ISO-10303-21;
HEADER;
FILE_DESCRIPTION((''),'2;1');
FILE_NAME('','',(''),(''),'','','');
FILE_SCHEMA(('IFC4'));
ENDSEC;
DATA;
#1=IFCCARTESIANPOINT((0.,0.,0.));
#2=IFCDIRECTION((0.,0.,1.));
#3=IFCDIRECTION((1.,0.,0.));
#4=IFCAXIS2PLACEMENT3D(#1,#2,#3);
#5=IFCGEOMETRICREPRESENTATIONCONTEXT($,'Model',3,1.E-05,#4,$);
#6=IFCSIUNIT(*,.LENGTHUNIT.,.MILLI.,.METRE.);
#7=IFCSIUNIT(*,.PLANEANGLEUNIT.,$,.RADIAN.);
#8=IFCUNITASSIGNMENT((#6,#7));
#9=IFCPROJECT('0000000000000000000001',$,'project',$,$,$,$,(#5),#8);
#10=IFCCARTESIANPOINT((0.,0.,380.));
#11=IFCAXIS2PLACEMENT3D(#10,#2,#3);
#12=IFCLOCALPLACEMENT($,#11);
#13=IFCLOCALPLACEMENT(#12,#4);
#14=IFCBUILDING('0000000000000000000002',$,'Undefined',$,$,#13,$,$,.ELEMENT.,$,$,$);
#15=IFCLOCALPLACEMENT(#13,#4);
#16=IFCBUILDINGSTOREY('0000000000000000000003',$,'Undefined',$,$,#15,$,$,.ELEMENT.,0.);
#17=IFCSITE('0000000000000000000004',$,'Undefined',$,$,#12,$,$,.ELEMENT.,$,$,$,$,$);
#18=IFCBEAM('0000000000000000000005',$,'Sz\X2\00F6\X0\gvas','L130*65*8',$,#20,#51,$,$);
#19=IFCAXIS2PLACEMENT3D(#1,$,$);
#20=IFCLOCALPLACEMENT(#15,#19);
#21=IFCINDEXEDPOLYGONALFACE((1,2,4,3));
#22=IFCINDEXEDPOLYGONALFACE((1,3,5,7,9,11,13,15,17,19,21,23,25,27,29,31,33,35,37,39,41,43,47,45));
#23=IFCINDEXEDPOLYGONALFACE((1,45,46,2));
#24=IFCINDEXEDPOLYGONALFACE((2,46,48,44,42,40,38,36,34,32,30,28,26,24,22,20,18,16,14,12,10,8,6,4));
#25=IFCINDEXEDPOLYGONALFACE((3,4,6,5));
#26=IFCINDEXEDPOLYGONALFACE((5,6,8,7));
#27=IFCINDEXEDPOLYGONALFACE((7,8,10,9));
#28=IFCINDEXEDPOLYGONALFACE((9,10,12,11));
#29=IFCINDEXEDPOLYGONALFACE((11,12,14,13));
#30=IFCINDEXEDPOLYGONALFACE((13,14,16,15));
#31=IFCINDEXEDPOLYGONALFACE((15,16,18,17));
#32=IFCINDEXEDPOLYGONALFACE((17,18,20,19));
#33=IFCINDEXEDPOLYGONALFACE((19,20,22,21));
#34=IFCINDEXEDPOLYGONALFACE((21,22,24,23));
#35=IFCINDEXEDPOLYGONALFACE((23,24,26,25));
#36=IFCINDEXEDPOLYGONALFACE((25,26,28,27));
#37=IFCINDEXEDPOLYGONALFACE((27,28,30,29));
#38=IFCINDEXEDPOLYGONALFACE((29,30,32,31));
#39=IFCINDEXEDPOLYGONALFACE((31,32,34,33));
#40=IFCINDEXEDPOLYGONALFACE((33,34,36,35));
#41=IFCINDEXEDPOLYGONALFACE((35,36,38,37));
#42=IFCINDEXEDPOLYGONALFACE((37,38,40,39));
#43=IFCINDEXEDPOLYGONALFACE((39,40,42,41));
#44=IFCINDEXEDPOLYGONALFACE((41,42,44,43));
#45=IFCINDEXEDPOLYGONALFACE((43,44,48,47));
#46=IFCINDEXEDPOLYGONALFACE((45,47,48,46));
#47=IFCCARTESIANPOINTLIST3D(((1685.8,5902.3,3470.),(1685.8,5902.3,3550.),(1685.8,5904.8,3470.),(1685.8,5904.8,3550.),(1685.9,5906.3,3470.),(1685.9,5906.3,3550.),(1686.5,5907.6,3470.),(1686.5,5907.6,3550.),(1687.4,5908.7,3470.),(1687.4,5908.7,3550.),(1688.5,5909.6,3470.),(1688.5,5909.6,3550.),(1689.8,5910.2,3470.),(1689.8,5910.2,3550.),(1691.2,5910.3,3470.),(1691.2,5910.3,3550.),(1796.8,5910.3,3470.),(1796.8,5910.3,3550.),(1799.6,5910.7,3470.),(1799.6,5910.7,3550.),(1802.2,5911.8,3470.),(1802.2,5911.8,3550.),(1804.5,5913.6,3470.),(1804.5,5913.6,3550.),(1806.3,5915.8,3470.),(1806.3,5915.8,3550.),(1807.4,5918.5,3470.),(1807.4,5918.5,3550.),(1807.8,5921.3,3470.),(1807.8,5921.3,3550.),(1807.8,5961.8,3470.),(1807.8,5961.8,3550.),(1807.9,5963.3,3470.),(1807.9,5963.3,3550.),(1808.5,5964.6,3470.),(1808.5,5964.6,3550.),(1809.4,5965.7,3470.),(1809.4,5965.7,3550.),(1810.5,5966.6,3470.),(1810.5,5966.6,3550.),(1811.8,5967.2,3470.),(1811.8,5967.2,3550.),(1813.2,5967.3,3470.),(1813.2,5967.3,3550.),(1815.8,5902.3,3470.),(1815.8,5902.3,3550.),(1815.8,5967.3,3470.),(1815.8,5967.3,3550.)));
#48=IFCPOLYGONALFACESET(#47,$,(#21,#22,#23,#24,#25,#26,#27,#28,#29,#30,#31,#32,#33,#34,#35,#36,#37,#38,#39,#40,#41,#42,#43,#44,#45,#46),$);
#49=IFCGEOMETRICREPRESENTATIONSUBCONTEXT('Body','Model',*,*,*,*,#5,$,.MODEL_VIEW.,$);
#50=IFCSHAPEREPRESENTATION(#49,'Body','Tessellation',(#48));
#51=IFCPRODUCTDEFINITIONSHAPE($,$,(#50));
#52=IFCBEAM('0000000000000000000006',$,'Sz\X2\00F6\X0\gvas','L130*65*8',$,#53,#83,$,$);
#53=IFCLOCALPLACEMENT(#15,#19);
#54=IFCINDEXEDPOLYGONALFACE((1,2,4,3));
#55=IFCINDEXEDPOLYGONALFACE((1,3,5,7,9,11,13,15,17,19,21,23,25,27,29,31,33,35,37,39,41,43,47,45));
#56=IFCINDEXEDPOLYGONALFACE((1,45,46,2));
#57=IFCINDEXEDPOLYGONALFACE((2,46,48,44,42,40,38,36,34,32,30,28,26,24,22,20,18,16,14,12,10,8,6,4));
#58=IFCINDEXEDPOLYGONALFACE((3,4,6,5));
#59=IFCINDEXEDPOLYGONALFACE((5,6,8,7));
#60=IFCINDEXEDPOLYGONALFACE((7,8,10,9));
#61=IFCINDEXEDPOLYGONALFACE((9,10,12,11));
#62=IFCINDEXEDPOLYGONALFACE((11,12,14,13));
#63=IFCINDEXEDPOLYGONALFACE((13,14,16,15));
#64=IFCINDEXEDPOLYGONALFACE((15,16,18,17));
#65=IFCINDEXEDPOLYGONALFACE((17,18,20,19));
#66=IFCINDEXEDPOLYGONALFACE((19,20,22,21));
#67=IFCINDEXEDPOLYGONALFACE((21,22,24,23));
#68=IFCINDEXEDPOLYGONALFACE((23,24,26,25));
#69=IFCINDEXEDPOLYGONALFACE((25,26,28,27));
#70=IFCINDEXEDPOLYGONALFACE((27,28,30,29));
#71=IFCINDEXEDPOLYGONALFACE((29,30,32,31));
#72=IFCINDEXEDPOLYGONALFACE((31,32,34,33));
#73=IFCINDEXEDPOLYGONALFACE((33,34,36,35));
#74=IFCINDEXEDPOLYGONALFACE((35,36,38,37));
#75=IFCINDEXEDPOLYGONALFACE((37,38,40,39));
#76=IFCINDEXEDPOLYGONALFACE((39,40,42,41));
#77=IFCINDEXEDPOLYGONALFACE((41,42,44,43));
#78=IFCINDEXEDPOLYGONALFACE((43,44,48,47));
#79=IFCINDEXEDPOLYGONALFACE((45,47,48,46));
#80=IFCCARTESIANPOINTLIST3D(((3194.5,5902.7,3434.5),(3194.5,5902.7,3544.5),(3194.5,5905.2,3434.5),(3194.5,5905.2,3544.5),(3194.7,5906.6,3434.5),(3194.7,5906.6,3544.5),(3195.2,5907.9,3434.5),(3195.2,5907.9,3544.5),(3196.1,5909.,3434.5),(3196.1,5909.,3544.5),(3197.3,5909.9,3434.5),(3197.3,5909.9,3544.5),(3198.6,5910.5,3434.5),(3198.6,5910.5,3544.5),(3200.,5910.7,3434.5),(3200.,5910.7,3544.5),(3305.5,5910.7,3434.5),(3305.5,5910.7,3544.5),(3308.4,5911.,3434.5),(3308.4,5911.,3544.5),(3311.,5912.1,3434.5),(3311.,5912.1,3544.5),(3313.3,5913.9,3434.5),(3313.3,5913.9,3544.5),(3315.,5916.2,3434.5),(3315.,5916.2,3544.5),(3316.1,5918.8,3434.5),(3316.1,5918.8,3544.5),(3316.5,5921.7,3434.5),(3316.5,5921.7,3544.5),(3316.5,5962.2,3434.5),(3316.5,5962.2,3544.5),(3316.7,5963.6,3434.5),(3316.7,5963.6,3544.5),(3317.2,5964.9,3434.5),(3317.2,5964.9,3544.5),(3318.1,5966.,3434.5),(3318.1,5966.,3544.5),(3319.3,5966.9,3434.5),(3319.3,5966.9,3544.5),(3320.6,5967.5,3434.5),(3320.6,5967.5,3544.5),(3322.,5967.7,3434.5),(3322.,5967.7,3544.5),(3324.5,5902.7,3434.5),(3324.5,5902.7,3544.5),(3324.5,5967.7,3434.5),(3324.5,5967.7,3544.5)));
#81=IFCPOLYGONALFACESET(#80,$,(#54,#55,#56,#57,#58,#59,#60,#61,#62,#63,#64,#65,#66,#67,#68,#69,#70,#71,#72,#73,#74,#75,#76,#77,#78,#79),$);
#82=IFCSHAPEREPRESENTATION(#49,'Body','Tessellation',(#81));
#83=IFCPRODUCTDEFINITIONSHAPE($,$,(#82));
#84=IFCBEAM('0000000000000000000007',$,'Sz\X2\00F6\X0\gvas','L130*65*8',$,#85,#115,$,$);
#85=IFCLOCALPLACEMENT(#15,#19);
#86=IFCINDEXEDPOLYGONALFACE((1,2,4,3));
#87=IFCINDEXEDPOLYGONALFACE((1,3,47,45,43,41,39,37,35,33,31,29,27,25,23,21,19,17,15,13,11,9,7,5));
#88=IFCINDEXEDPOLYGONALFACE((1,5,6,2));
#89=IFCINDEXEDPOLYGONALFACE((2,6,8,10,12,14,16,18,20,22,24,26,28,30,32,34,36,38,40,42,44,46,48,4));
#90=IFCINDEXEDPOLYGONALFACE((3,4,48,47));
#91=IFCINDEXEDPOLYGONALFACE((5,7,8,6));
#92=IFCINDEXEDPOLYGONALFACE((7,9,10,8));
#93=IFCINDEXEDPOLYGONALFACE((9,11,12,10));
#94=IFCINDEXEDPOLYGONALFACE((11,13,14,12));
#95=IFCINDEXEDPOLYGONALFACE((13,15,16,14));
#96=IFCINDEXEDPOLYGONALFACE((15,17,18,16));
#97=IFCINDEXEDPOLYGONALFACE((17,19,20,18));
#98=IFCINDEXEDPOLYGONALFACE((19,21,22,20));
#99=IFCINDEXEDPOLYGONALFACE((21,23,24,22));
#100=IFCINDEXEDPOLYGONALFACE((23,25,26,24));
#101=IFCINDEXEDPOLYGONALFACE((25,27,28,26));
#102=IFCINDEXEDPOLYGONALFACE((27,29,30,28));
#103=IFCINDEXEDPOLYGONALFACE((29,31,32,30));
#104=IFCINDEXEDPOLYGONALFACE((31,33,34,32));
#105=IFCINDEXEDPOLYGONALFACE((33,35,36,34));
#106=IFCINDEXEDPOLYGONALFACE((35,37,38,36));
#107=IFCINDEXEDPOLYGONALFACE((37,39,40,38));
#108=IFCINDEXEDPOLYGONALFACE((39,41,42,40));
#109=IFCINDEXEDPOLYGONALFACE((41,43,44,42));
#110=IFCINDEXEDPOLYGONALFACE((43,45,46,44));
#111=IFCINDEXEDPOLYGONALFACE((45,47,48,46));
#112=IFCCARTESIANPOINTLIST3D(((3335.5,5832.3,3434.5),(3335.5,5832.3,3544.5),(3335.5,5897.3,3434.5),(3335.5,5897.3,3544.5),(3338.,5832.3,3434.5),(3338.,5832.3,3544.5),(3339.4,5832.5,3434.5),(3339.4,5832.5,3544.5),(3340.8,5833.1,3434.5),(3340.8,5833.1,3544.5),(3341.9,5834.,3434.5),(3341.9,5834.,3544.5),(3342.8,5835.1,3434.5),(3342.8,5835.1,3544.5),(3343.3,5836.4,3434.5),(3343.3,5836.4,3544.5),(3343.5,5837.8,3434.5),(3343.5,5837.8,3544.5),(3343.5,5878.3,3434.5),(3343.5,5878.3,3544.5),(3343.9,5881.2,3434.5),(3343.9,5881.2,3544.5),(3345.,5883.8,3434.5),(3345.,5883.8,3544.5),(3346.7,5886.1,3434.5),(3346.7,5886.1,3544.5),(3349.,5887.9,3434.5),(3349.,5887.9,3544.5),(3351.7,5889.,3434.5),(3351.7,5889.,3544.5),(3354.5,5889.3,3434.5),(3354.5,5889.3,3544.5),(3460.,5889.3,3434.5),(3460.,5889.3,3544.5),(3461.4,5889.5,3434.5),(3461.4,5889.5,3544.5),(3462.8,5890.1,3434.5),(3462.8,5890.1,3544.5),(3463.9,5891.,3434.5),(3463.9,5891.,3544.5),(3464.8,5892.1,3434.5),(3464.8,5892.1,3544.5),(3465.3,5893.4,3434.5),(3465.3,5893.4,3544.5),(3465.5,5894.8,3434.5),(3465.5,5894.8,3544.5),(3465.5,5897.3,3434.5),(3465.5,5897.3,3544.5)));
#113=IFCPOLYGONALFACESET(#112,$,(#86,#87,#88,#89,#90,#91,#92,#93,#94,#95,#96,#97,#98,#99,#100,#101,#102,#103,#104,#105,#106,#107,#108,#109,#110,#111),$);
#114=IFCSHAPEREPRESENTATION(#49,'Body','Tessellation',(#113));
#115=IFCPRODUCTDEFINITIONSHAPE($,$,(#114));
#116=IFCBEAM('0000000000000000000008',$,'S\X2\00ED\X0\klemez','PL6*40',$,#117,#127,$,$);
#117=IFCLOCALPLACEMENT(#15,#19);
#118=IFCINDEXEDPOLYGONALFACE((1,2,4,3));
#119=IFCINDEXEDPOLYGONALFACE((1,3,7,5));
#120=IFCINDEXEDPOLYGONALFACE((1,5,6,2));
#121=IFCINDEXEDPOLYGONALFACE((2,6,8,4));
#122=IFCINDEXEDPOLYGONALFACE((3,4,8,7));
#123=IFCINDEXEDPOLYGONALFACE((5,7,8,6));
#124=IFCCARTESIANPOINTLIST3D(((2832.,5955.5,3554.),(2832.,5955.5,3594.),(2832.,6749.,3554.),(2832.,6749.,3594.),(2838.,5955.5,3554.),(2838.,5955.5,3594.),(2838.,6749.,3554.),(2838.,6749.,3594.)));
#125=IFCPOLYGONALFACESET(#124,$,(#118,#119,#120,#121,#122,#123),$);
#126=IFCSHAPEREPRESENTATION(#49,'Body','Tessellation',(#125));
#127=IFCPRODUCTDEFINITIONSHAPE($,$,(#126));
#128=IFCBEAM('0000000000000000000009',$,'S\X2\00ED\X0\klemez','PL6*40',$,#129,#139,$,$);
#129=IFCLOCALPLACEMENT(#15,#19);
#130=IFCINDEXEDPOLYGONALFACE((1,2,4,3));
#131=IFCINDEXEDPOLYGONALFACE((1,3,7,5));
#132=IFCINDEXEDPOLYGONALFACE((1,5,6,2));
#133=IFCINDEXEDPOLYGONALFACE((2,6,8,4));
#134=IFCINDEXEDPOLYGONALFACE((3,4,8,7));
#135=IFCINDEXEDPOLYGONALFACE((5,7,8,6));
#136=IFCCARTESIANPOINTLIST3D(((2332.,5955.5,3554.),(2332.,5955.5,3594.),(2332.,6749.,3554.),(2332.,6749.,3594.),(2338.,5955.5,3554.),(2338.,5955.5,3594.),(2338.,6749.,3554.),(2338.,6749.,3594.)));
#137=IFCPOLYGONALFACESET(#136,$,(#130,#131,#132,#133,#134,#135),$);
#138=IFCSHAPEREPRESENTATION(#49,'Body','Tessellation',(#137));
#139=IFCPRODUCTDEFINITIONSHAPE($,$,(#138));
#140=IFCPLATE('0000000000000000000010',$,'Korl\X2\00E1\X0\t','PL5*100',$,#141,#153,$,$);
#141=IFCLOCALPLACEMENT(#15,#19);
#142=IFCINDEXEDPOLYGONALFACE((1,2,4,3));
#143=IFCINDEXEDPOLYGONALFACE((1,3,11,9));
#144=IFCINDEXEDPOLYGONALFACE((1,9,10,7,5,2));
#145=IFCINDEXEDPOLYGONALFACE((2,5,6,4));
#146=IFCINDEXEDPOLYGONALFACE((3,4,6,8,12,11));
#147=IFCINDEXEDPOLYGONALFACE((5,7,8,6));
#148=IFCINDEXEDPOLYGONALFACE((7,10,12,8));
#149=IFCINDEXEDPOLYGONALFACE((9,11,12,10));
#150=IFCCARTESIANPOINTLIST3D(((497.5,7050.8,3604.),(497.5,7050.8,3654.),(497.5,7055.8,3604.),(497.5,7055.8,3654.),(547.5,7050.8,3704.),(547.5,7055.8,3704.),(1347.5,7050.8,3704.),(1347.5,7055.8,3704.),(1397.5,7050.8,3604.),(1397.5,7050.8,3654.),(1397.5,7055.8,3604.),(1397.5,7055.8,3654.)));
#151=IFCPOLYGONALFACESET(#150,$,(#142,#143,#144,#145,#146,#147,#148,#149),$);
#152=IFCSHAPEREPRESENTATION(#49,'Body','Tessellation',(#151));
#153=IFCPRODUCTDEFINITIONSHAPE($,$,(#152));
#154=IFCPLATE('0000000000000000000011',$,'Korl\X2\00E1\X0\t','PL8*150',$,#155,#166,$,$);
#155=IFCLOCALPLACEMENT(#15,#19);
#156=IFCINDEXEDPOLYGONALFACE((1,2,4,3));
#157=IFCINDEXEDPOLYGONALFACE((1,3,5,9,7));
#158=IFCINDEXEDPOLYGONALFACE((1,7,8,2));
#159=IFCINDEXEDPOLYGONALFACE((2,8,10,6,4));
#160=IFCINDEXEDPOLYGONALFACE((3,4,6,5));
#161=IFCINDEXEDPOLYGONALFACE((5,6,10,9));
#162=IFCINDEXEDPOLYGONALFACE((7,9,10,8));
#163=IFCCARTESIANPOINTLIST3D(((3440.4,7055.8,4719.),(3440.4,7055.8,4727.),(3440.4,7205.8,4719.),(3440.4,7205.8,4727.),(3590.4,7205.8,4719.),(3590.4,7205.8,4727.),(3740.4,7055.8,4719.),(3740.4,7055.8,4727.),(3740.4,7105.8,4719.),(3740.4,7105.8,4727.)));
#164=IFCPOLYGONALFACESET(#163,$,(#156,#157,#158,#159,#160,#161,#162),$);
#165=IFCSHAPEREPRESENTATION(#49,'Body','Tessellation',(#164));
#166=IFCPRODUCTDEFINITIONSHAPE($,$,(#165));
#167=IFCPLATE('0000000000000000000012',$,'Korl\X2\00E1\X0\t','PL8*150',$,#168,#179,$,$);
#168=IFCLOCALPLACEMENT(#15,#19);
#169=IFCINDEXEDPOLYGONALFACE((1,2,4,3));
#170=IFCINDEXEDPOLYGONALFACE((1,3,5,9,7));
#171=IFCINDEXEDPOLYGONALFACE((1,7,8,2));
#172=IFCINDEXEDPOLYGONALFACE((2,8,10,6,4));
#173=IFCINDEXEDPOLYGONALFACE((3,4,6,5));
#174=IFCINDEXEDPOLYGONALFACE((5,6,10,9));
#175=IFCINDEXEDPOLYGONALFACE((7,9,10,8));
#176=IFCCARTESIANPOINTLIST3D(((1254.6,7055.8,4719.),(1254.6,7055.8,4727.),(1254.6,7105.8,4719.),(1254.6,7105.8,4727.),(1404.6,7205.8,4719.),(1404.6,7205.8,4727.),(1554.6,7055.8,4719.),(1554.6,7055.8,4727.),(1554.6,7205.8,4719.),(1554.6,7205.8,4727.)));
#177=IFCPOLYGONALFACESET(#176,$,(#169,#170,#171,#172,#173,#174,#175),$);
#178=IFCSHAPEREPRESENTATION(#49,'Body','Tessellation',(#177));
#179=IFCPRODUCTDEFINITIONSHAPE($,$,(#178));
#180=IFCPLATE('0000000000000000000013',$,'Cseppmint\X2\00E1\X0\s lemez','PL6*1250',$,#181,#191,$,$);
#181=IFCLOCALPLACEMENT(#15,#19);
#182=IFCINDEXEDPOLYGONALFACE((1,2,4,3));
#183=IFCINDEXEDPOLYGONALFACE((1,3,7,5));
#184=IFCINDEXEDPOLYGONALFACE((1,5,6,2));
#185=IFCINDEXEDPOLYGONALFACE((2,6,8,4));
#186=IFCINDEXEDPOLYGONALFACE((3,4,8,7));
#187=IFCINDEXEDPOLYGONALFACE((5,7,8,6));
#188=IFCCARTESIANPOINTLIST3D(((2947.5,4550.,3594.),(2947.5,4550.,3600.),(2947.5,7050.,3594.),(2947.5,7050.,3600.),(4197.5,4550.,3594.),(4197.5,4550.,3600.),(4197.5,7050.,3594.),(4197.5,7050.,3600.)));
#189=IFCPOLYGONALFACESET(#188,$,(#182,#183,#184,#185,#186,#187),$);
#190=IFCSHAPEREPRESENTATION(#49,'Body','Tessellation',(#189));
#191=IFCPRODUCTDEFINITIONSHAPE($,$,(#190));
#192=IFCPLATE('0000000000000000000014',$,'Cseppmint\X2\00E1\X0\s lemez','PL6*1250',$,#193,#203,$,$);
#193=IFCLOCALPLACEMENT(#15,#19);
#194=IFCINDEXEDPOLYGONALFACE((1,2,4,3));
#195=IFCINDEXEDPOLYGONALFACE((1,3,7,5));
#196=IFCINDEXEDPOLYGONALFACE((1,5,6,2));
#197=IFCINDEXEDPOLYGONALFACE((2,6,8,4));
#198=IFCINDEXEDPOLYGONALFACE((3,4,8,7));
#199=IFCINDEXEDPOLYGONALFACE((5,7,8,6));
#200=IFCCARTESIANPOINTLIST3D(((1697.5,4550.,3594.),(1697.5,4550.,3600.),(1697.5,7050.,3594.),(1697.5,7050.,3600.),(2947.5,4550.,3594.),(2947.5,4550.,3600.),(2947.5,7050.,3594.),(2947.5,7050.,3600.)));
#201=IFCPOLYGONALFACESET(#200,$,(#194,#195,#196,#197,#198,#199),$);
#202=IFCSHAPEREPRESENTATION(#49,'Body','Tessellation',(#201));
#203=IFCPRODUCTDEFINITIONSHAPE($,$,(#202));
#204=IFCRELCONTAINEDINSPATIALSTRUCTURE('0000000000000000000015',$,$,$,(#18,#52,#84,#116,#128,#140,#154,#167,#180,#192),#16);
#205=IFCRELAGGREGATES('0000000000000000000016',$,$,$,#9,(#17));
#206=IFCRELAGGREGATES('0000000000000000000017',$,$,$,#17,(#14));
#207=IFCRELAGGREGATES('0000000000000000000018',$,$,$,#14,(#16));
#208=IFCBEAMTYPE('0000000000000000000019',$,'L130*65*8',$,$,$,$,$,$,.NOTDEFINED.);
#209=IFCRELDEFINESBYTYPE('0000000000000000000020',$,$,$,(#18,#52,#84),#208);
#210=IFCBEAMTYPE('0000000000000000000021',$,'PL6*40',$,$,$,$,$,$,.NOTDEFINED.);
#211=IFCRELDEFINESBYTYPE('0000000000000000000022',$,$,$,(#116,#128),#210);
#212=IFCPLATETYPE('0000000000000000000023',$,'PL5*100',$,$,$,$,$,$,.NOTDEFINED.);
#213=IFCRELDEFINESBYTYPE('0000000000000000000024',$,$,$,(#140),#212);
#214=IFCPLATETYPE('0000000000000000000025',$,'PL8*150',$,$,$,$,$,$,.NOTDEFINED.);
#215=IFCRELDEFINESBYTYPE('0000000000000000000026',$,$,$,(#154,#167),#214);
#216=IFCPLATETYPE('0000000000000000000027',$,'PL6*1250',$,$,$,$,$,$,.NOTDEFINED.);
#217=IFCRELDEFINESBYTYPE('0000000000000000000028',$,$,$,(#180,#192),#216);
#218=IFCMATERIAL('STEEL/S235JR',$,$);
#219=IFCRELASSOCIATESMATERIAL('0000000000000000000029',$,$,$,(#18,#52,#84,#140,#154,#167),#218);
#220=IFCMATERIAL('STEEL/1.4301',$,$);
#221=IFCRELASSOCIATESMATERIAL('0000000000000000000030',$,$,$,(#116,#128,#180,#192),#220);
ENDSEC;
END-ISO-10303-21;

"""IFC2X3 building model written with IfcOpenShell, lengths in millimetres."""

from ifc_helpers import new_model, si_unit, frame, origin_with_axes, origin_2d_with_axis, place, context, subcontext, project, spatial, polyline, rectangle, l_section, outline, extrude, material, type_object, element, save


model = new_model("IFC2X3")

# Units and contexts
model_context = context("Model", 3, precision=1e-05, world=origin_with_axes())
body_context = subcontext(model_context, "Body", "Model", "MODEL_VIEW")
ifc_project = project(units=[si_unit("LENGTHUNIT", "METRE", prefix="MILLI"), si_unit("PLANEANGLEUNIT", "RADIAN")], contexts=[model_context])

# Site, building, storey
site_placement = place(None, frame((0.0, 0.0, 380.0), z_axis=(0.0, 0.0, 1.0), x_axis=(1.0, 0.0, 0.0)))
site = spatial("IfcSite", under=ifc_project, at=site_placement, Name="Undefined", CompositionType="ELEMENT")
building_placement = place(site_placement, origin_with_axes())
building = spatial("IfcBuilding", under=site, at=building_placement, Name="Undefined", CompositionType="ELEMENT")
storey_placement = place(building_placement, origin_with_axes())
storey = spatial("IfcBuildingStorey", under=building, at=storey_placement, Name="Undefined", CompositionType="ELEMENT", Elevation=0.0)

# Beams
ifc_material_1 = material(Name="STEEL/S235JR")
beam_type_1 = type_object("IfcBeamType", Name="L130*65*8", PredefinedType="NOTDEFINED")
beam_1_placement = place(storey_placement, frame((1750.8, 5934.8, 3550.0), z_axis=(-1.0, 0.0, 0.0), x_axis=(0.0, 0.0, -1.0)))
element("IfcBeam", 1, at=beam_1_placement, inside=storey, type_object=beam_type_1, material=ifc_material_1, Name="Szögvas", Description="L130*65*8", context=body_context, shape_type="SweptSolid", body=[
    extrude(l_section(Depth=130.0, Width=65.0, Thickness=8.0, FilletRadius=11.0, EdgeRadius=5.5, at=origin_2d_with_axis()), frame((80.0, 0.0, 0.0), z_axis=(-1.0, 0.0, 0.0), x_axis=(0.0, -1.0, 0.0)), (0.0, 0.0, 1.0), 80.0),
])
for number, where, z_axis, x_axis, name in (
    (2, (3259.5, 5935.2, 3544.5), (-1.0, 0.0, 0.0), (0.0, 0.0, -1.0), "Szögvas"),
    (3, (3400.5, 5864.8, 3544.5), (1.0, 0.0, 0.0), (0.0, 0.0, -1.0), "Szögvas"),
):
    element("IfcBeam", number, at=place(storey_placement, frame(where, z_axis=z_axis, x_axis=x_axis)), inside=storey, type_object=beam_type_1, material=ifc_material_1, Name=name, Description="L130*65*8", context=body_context, shape_type="SweptSolid", body=[
        extrude(l_section(Depth=130.0, Width=65.0, Thickness=8.0, FilletRadius=11.0, EdgeRadius=5.5, at=origin_2d_with_axis()), frame((110.0, 0.0, 0.0), z_axis=(-1.0, 0.0, 0.0), x_axis=(0.0, -1.0, 0.0)), (0.0, 0.0, 1.0), 110.0),
    ])
ifc_material_2 = material(Name="STEEL/1.4301")
beam_type_2 = type_object("IfcBeamType", Name="PL6*40", PredefinedType="NOTDEFINED")
for number, where, z_axis, x_axis, name in (
    (4, (2835.0, 6749.0, 3574.0), (0.0, 0.0, 1.0), (0.0, -1.0, 0.0), "Síklemez"),
    (5, (2335.0, 6749.0, 3574.0), (0.0, 0.0, 1.0), (0.0, -1.0, 0.0), "Síklemez"),
):
    element("IfcBeam", number, at=place(storey_placement, frame(where, z_axis=z_axis, x_axis=x_axis)), inside=storey, type_object=beam_type_2, material=ifc_material_2, Name=name, Description="PL6*40", context=body_context, shape_type="SweptSolid", body=[
        extrude(rectangle(XDim=6.0, YDim=40.0, at=origin_2d_with_axis()), frame((793.5, 0.0, 0.0), z_axis=(-1.0, 0.0, 0.0), x_axis=(0.0, -1.0, 0.0)), (0.0, 0.0, 1.0), 793.5),
    ])

# Plates
plate_type_1 = type_object("IfcPlateType", Name="PL5*100", PredefinedType="NOTDEFINED")
plate_placement = place(storey_placement, frame((1397.5, 7053.3, 3604.0), z_axis=(0.0, 1.0, 0.0), x_axis=(-1.0, 0.0, 0.0)))
element("IfcPlate", 6, at=plate_placement, inside=storey, type_object=plate_type_1, material=ifc_material_1, Name="Korlát", Description="PL5*100", context=body_context, shape_type="SweptSolid", body=[
    extrude(outline(polyline([(0.0, 0.0), (900.0, 0.0), (900.0, 50.0), (850.0, 100.0), (50.0, 100.0), (0.0, 50.0), (0.0, 0.0)])), frame((0.0, 0.0, -2.5), z_axis=(0.0, 0.0, 1.0), x_axis=(1.0, 0.0, 0.0)), (0.0, 0.0, 1.0), 5.0),
])
plate_type_2 = type_object("IfcPlateType", Name="PL8*150", PredefinedType="NOTDEFINED")
for number, where, z_axis, x_axis, name in (
    (7, (3440.4, 7055.8, 4723.0), (0.0, 0.0, -1.0), (0.0, 1.0, 0.0), "Korlát"),
    (8, (1554.6, 7055.8, 4723.0), (0.0, 0.0, 1.0), (0.0, 1.0, 0.0), "Korlát"),
):
    element("IfcPlate", number, at=place(storey_placement, frame(where, z_axis=z_axis, x_axis=x_axis)), inside=storey, type_object=plate_type_2, material=ifc_material_1, Name=name, Description="PL8*150", context=body_context, shape_type="SweptSolid", body=[
        extrude(outline(polyline([(0.0, 0.0), (150.0, 0.0), (150.0, 150.0), (50.0, 300.0), (0.0, 300.0), (0.0, 0.0)])), frame((0.0, 0.0, -4.0), z_axis=(0.0, 0.0, 1.0), x_axis=(1.0, 0.0, 0.0)), (0.0, 0.0, 1.0), 8.0),
    ])
plate_type_3 = type_object("IfcPlateType", Name="PL6*1250", PredefinedType="NOTDEFINED")
for number, where, z_axis, x_axis, name in (
    (9, (2947.5, 7050.0, 3597.0), (0.0, 0.0, 1.0), (0.0, -1.0, 0.0), "Cseppmintás lemez"),
    (10, (1697.5, 7050.0, 3597.0), (0.0, 0.0, 1.0), (0.0, -1.0, 0.0), "Cseppmintás lemez"),
):
    element("IfcPlate", number, at=place(storey_placement, frame(where, z_axis=z_axis, x_axis=x_axis)), inside=storey, type_object=plate_type_3, material=ifc_material_2, Name=name, Description="PL6*1250", context=body_context, shape_type="SweptSolid", body=[
        extrude(outline(polyline([(0.0, 0.0), (2500.0, 0.0), (2500.0, 1250.0), (0.0, 1250.0), (0.0, 0.0)])), frame((0.0, 0.0, -3.0), z_axis=(0.0, 0.0, 1.0), x_axis=(1.0, 0.0, 0.0)), (0.0, 0.0, 1.0), 6.0),
    ])

save(model, "model.ifc")
